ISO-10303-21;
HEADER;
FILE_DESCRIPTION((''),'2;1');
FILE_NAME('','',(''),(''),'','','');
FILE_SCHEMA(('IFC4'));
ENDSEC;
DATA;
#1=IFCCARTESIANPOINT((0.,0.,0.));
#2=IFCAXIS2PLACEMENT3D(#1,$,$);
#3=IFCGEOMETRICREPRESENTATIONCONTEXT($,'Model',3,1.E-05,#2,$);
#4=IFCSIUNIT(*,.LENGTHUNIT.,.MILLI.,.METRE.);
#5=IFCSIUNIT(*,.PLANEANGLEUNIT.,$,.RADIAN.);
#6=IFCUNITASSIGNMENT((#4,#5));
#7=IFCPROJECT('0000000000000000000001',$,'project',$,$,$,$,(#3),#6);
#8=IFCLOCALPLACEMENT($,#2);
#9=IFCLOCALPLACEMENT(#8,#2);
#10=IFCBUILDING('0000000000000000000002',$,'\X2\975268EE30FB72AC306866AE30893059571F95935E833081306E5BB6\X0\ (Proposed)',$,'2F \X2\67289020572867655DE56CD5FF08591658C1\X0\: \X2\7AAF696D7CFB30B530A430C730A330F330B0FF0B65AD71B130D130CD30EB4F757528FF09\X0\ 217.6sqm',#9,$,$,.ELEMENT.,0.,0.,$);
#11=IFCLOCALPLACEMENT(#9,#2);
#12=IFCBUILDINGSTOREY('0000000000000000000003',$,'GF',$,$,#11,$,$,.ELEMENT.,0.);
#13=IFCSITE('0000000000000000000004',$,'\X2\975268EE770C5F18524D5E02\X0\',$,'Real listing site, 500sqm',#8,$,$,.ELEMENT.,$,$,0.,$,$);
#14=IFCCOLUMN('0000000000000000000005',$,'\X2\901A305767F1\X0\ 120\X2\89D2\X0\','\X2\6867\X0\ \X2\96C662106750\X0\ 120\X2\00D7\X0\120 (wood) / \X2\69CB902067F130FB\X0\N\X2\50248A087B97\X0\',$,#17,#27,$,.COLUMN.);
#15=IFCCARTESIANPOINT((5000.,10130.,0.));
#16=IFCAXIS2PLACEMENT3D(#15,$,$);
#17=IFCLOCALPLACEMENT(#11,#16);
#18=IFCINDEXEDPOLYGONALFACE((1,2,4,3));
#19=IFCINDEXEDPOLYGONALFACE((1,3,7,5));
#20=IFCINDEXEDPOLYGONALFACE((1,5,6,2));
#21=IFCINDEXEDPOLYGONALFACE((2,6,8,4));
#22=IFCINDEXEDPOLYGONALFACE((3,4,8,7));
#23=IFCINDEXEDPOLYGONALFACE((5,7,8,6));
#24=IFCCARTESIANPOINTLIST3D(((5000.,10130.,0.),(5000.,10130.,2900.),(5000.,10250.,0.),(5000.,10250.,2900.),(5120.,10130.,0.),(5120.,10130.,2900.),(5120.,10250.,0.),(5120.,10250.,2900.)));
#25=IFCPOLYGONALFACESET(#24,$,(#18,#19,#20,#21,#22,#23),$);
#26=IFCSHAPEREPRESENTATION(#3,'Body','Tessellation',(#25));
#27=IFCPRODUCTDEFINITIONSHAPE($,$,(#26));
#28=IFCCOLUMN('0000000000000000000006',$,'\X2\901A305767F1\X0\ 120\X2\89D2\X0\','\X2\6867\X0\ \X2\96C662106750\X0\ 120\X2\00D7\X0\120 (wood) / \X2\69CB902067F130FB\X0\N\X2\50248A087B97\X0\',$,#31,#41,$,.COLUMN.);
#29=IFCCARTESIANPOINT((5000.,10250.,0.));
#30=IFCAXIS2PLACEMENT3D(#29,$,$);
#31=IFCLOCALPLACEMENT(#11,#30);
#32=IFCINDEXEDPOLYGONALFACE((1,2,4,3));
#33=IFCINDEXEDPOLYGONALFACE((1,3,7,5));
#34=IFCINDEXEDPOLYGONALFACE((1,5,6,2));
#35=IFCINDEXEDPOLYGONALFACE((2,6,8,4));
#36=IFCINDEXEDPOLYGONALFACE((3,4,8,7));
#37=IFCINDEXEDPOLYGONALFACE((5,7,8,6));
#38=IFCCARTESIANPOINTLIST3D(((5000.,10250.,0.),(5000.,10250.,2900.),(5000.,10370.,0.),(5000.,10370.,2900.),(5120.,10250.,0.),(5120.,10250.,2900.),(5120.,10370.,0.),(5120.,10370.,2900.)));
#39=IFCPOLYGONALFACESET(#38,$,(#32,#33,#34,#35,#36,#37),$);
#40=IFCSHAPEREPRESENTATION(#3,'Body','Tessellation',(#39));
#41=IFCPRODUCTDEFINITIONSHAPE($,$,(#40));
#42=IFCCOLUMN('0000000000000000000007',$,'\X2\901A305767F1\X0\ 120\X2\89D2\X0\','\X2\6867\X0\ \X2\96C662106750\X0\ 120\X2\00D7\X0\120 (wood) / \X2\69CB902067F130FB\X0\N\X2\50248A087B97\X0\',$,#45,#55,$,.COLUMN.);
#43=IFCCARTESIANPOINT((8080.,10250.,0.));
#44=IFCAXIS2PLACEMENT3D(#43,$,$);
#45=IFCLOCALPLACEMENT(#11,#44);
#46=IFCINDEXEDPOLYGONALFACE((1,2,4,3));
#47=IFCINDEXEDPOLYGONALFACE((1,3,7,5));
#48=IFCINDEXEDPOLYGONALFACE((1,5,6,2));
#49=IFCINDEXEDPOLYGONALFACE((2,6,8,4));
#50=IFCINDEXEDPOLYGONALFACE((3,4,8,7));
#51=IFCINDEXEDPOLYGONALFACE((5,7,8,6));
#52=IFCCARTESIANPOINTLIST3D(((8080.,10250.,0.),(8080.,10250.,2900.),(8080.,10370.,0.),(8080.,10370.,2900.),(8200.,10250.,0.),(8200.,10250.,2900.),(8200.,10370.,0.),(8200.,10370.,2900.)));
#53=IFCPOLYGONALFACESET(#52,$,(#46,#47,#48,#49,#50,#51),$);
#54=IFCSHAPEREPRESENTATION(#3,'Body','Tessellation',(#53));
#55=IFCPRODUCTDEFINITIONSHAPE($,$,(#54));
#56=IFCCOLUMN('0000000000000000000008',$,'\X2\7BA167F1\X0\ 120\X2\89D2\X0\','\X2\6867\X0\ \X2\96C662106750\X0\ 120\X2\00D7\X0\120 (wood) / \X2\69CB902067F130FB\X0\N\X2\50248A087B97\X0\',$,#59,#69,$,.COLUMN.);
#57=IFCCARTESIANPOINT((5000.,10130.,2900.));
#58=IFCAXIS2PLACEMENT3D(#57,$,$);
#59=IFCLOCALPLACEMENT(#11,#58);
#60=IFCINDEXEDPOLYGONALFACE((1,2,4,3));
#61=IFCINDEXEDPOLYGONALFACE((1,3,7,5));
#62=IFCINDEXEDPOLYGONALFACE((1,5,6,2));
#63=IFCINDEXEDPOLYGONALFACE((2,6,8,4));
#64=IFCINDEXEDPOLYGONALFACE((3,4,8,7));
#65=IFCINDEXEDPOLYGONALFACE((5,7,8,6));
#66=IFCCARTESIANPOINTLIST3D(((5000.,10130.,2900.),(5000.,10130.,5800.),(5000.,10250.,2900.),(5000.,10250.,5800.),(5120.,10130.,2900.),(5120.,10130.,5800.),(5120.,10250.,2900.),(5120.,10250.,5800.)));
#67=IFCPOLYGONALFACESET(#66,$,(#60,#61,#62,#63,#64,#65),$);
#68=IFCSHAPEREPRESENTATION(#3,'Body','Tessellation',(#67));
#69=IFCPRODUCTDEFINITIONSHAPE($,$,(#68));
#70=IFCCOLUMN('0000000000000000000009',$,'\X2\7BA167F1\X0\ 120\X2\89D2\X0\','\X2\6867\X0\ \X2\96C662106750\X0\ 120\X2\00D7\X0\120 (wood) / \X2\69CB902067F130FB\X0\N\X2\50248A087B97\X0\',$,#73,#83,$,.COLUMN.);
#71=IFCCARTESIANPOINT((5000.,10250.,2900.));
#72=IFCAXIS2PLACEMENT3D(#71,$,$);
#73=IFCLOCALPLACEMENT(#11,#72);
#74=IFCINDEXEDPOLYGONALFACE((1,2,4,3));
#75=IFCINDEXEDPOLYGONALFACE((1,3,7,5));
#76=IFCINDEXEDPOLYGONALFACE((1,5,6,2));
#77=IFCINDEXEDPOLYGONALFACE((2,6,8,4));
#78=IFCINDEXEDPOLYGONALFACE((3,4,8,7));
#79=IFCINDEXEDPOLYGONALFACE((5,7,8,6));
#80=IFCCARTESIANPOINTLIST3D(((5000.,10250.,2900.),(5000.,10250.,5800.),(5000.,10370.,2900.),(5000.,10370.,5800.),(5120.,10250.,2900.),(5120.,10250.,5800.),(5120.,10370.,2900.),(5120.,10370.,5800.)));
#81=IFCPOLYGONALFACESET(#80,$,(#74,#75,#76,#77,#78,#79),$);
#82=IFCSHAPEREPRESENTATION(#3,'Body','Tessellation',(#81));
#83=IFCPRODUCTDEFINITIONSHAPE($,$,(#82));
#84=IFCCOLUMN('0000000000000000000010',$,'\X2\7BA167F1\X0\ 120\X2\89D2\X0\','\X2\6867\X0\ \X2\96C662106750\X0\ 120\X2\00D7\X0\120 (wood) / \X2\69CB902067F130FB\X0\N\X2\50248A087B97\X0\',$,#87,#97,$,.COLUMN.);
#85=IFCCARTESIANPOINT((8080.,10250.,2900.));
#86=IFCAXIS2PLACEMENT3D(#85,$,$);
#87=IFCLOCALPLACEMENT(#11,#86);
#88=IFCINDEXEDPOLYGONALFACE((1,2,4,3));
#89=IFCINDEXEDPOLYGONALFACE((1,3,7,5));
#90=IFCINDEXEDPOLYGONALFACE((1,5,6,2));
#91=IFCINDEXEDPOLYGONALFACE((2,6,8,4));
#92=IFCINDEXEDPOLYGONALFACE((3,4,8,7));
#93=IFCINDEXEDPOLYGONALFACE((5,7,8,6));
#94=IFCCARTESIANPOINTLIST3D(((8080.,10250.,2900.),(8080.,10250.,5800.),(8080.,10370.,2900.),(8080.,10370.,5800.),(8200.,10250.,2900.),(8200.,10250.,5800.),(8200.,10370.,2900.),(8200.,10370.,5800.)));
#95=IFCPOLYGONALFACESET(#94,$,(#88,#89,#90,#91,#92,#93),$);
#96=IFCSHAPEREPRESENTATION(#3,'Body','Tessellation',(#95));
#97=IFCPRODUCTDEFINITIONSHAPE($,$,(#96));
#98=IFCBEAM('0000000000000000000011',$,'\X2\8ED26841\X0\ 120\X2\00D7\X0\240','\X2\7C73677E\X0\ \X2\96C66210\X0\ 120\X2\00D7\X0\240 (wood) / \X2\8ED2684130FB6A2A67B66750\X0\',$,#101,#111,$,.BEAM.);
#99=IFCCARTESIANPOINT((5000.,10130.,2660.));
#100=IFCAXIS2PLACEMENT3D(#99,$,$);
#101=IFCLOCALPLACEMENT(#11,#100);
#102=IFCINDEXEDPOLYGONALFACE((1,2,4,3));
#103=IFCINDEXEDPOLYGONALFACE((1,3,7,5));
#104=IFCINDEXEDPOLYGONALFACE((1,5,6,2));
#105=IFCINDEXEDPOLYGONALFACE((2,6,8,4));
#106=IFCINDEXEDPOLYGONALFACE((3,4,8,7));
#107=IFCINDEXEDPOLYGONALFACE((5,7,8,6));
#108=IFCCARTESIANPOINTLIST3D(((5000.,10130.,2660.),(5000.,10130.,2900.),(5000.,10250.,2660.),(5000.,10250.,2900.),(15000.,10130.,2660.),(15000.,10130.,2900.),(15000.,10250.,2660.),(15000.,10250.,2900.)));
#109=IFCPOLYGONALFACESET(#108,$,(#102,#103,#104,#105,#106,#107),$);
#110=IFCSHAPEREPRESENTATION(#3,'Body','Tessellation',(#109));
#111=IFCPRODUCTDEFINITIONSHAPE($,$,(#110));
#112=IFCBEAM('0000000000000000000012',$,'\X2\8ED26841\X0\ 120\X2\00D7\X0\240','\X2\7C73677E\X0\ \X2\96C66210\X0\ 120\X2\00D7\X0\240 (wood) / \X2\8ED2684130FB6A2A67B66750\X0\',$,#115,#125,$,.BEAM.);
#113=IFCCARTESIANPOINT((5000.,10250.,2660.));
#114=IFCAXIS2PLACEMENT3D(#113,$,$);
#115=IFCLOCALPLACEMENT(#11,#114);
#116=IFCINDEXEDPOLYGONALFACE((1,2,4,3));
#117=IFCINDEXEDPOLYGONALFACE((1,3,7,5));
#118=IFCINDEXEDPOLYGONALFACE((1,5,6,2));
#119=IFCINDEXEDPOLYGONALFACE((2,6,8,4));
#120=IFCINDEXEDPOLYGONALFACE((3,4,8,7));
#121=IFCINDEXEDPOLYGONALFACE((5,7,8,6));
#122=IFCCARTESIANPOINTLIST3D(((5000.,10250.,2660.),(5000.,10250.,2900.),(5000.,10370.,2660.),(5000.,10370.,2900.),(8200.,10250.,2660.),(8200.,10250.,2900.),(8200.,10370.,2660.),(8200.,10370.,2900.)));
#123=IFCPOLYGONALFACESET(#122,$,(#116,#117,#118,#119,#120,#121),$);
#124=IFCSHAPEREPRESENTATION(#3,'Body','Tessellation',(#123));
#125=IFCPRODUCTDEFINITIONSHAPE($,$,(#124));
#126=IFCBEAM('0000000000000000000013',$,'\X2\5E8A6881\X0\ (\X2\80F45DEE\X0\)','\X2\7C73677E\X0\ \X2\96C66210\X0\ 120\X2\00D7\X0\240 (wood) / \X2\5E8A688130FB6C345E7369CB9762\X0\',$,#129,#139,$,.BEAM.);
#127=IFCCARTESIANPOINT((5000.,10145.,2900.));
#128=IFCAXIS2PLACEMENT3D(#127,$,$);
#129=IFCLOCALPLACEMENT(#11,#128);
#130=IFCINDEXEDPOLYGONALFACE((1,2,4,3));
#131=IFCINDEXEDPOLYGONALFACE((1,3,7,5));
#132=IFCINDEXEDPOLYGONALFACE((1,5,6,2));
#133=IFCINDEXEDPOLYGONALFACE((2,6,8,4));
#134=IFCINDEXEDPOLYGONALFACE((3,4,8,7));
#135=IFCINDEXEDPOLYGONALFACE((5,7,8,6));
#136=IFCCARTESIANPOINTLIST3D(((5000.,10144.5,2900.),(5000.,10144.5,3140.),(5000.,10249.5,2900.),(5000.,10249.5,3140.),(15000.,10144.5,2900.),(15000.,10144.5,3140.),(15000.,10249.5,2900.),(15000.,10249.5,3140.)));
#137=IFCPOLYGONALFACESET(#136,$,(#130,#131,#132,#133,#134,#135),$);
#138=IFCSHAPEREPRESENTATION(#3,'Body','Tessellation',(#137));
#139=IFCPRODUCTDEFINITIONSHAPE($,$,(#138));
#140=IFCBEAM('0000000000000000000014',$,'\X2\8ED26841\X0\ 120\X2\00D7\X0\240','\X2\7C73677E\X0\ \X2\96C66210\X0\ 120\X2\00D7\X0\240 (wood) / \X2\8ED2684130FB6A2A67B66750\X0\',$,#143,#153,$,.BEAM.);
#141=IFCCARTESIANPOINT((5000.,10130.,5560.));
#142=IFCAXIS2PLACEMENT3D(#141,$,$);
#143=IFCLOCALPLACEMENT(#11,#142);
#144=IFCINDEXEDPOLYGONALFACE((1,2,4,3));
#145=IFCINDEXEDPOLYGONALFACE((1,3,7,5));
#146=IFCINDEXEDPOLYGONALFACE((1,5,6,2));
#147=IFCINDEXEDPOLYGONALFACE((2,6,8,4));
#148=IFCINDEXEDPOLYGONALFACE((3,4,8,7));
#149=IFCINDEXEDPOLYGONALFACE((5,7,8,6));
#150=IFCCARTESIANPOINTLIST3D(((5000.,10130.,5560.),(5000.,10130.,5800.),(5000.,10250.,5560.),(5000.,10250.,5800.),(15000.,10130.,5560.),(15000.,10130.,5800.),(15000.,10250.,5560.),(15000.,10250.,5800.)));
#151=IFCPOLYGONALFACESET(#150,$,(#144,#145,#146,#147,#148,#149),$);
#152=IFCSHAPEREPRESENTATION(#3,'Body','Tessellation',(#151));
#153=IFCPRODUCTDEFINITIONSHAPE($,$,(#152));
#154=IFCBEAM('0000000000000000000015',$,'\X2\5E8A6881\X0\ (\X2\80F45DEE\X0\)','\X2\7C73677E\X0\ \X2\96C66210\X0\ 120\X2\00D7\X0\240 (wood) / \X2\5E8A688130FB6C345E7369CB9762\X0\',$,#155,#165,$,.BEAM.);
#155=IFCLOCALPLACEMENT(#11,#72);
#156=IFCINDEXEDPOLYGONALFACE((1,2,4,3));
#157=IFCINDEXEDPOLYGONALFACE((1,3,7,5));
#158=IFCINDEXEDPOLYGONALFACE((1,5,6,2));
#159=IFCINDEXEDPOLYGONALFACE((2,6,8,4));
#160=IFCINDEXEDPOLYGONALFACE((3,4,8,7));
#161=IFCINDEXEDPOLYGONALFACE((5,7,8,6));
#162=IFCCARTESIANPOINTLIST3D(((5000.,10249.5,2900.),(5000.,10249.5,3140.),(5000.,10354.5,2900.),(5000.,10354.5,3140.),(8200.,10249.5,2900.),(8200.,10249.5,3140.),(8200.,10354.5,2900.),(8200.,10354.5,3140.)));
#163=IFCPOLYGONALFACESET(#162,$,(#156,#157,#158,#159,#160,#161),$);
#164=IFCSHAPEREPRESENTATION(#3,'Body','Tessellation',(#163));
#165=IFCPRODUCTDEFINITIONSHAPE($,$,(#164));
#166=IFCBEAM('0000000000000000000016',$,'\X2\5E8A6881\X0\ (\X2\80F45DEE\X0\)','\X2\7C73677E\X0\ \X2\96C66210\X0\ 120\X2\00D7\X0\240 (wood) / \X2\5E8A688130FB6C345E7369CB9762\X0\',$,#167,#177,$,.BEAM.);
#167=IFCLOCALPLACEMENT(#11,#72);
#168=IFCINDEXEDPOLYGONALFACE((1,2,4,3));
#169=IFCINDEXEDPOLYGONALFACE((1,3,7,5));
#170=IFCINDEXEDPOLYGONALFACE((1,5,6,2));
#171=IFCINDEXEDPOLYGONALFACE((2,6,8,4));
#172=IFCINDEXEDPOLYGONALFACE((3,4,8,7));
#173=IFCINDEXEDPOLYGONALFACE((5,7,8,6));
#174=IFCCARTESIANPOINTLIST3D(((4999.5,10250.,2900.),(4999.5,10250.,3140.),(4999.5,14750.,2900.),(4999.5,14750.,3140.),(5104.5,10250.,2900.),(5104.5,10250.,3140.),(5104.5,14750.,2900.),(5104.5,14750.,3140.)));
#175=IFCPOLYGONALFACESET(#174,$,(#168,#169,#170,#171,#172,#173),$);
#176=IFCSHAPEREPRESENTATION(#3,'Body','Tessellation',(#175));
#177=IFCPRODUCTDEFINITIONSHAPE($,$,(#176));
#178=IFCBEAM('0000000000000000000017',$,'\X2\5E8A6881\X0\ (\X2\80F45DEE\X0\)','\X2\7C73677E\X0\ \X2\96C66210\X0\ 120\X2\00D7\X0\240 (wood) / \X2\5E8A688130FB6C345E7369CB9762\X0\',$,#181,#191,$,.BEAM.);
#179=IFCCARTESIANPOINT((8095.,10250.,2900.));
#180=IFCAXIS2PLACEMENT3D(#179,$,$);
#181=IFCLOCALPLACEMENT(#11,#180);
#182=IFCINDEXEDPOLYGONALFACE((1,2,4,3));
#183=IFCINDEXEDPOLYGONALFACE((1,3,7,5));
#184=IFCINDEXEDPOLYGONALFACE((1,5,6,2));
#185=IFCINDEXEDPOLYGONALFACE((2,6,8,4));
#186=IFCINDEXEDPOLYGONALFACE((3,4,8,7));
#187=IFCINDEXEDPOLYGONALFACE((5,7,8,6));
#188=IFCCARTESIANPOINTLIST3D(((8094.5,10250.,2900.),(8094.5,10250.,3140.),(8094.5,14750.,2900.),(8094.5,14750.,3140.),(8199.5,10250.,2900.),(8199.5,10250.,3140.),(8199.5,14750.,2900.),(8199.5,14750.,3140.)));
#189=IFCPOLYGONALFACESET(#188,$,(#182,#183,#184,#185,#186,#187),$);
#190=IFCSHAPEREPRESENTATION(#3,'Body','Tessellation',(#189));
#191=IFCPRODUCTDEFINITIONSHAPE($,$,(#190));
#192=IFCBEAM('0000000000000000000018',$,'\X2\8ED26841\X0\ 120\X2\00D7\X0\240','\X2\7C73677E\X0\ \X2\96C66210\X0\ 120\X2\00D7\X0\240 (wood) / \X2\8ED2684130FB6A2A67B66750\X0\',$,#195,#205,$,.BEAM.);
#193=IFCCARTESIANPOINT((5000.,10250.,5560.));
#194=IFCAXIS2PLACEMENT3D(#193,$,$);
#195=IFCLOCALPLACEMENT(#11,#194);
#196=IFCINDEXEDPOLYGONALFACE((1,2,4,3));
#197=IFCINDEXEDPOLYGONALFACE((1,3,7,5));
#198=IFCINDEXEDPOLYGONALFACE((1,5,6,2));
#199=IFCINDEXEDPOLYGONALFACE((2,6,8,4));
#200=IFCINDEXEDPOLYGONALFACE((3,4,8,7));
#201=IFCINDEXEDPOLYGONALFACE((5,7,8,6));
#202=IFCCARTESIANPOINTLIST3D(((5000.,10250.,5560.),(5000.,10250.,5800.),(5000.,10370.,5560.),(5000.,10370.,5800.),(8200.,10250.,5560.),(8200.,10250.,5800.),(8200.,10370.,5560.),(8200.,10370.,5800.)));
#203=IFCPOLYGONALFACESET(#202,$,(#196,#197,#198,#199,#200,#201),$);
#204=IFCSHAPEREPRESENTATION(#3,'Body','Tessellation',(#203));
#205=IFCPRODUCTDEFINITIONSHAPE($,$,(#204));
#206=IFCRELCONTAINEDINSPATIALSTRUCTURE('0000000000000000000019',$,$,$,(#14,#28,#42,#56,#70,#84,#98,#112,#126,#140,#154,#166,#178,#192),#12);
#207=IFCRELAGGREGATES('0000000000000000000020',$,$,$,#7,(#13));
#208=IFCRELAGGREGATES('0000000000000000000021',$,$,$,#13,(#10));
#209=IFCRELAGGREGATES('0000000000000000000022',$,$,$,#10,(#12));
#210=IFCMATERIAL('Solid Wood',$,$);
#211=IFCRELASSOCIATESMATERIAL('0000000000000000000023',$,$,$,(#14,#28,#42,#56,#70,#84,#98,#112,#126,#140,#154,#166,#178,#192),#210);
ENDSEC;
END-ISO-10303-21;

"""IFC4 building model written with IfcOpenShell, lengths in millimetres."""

from ifc_helpers import new_model, si_unit, frame, frame_2d, origin, place, context, project, spatial, rectangle, extrude, material, element, save


model = new_model("IFC4")

# Units and contexts
model_context = context("Model", 3, precision=1e-05, world=origin())
ifc_project = project(units=[si_unit("LENGTHUNIT", "METRE", prefix="MILLI"), si_unit("PLANEANGLEUNIT", "RADIAN")], contexts=[model_context])

# Site, building, storey
site_placement = place(None, origin())
site = spatial("IfcSite", under=ifc_project, at=site_placement, Name="青森県弘前市", ObjectType="Real listing site, 500sqm", CompositionType="ELEMENT", RefElevation=0.0)
building_placement = place(site_placement, origin())
building = spatial("IfcBuilding", under=site, at=building_placement, Name="青森・犬と暮らす土間広めの家 (Proposed)", ObjectType="2F 木造在来工法（外壁: 窯業系サイディング＋断熱パネル併用） 217.6sqm", CompositionType="ELEMENT", ElevationOfRefHeight=0.0, ElevationOfTerrain=0.0)
storey_placement = place(building_placement, origin())
storey = spatial("IfcBuildingStorey", under=building, at=storey_placement, Name="GF", CompositionType="ELEMENT", Elevation=0.0)

# Columns
ifc_material_1 = material(Name="Solid Wood")
column_1_placement = place(storey_placement, frame((5000.0, 10130.0, 0.0)))
element("IfcColumn", 1, at=column_1_placement, inside=storey, material=ifc_material_1, Name="通し柱 120角", Description="桧 集成材 120×120 (wood) / 構造柱・N値計算", PredefinedType="COLUMN", context=model_context, shape_type="SweptSolid", body=[
    extrude(rectangle(XDim=120.0, YDim=120.0, at=frame_2d((60.0, 60.0))), frame((5000.0, 10130.0, 0.0)), (0.0, 0.0, 1.0), 2900.0),
])
column_2_placement = place(storey_placement, frame((5000.0, 10250.0, 0.0)))
element("IfcColumn", 2, at=column_2_placement, inside=storey, material=ifc_material_1, Name="通し柱 120角", Description="桧 集成材 120×120 (wood) / 構造柱・N値計算", PredefinedType="COLUMN", context=model_context, shape_type="SweptSolid", body=[
    extrude(rectangle(XDim=120.0, YDim=120.0, at=frame_2d((60.0, 60.0))), frame((5000.0, 10250.0, 0.0)), (0.0, 0.0, 1.0), 2900.0),
])
column_3_placement = place(storey_placement, frame((8080.0, 10250.0, 0.0)))
element("IfcColumn", 3, at=column_3_placement, inside=storey, material=ifc_material_1, Name="通し柱 120角", Description="桧 集成材 120×120 (wood) / 構造柱・N値計算", PredefinedType="COLUMN", context=model_context, shape_type="SweptSolid", body=[
    extrude(rectangle(XDim=120.0, YDim=120.0, at=frame_2d((60.0, 60.0))), frame((8080.0, 10250.0, 0.0)), (0.0, 0.0, 1.0), 2900.0),
])
column_4_placement = place(storey_placement, frame((5000.0, 10130.0, 2900.0)))
element("IfcColumn", 4, at=column_4_placement, inside=storey, material=ifc_material_1, Name="管柱 120角", Description="桧 集成材 120×120 (wood) / 構造柱・N値計算", PredefinedType="COLUMN", context=model_context, shape_type="SweptSolid", body=[
    extrude(rectangle(XDim=120.0, YDim=120.0, at=frame_2d((60.0, 60.0))), frame((5000.0, 10130.0, 2900.0)), (0.0, 0.0, 1.0), 2900.0),
])
column_5_placement = place(storey_placement, frame((5000.0, 10250.0, 2900.0)))
element("IfcColumn", 5, at=column_5_placement, inside=storey, material=ifc_material_1, Name="管柱 120角", Description="桧 集成材 120×120 (wood) / 構造柱・N値計算", PredefinedType="COLUMN", context=model_context, shape_type="SweptSolid", body=[
    extrude(rectangle(XDim=120.0, YDim=120.0, at=frame_2d((60.0, 60.0))), frame((5000.0, 10250.0, 2900.0)), (0.0, 0.0, 1.0), 2900.0),
])
column_6_placement = place(storey_placement, frame((8080.0, 10250.0, 2900.0)))
element("IfcColumn", 6, at=column_6_placement, inside=storey, material=ifc_material_1, Name="管柱 120角", Description="桧 集成材 120×120 (wood) / 構造柱・N値計算", PredefinedType="COLUMN", context=model_context, shape_type="SweptSolid", body=[
    extrude(rectangle(XDim=120.0, YDim=120.0, at=frame_2d((60.0, 60.0))), frame((8080.0, 10250.0, 2900.0)), (0.0, 0.0, 1.0), 2900.0),
])

# Beams
beam_1_placement = place(storey_placement, frame((5000.0, 10130.0, 2660.0)))
element("IfcBeam", 7, at=beam_1_placement, inside=storey, material=ifc_material_1, Name="軒桁 120×240", Description="米松 集成 120×240 (wood) / 軒桁・横架材", PredefinedType="BEAM", context=model_context, shape_type="SweptSolid", body=[
    extrude(rectangle(XDim=10000.0, YDim=120.0, at=frame_2d((5000.0, 60.0))), frame((5000.0, 10130.0, 2660.0)), (0.0, 0.0, 1.0), 240.0),
])
beam_2_placement = place(storey_placement, frame((5000.0, 10250.0, 2660.0)))
element("IfcBeam", 8, at=beam_2_placement, inside=storey, material=ifc_material_1, Name="軒桁 120×240", Description="米松 集成 120×240 (wood) / 軒桁・横架材", PredefinedType="BEAM", context=model_context, shape_type="SweptSolid", body=[
    extrude(rectangle(XDim=3200.0, YDim=120.0, at=frame_2d((1600.0, 60.0))), frame((5000.0, 10250.0, 2660.0)), (0.0, 0.0, 1.0), 240.0),
])
beam_3_placement = place(storey_placement, frame((5000.0, 10145.0, 2900.0)))
element("IfcBeam", 9, at=beam_3_placement, inside=storey, material=ifc_material_1, Name="床梁 (胴差)", Description="米松 集成 120×240 (wood) / 床梁・水平構面", PredefinedType="BEAM", context=model_context, shape_type="SweptSolid", body=[
    extrude(rectangle(XDim=10000.0, YDim=105.0, at=frame_2d((5000.0, 52.0))), frame((5000.0, 10145.0, 2900.0)), (0.0, 0.0, 1.0), 240.0),
])
beam_4_placement = place(storey_placement, frame((5000.0, 10130.0, 5560.0)))
element("IfcBeam", 10, at=beam_4_placement, inside=storey, material=ifc_material_1, Name="軒桁 120×240", Description="米松 集成 120×240 (wood) / 軒桁・横架材", PredefinedType="BEAM", context=model_context, shape_type="SweptSolid", body=[
    extrude(rectangle(XDim=10000.0, YDim=120.0, at=frame_2d((5000.0, 60.0))), frame((5000.0, 10130.0, 5560.0)), (0.0, 0.0, 1.0), 240.0),
])
beam_5_placement = place(storey_placement, frame((5000.0, 10250.0, 2900.0)))
element("IfcBeam", 11, at=beam_5_placement, inside=storey, material=ifc_material_1, Name="床梁 (胴差)", Description="米松 集成 120×240 (wood) / 床梁・水平構面", PredefinedType="BEAM", context=model_context, shape_type="SweptSolid", body=[
    extrude(rectangle(XDim=3200.0, YDim=105.0, at=frame_2d((1600.0, 52.0))), frame((5000.0, 10250.0, 2900.0)), (0.0, 0.0, 1.0), 240.0),
])
beam_6_placement = place(storey_placement, frame((5000.0, 10250.0, 2900.0)))
element("IfcBeam", 12, at=beam_6_placement, inside=storey, material=ifc_material_1, Name="床梁 (胴差)", Description="米松 集成 120×240 (wood) / 床梁・水平構面", PredefinedType="BEAM", context=model_context, shape_type="SweptSolid", body=[
    extrude(rectangle(XDim=105.0, YDim=4500.0, at=frame_2d((52.0, 2250.0))), frame((5000.0, 10250.0, 2900.0)), (0.0, 0.0, 1.0), 240.0),
])
beam_7_placement = place(storey_placement, frame((8095.0, 10250.0, 2900.0)))
element("IfcBeam", 13, at=beam_7_placement, inside=storey, material=ifc_material_1, Name="床梁 (胴差)", Description="米松 集成 120×240 (wood) / 床梁・水平構面", PredefinedType="BEAM", context=model_context, shape_type="SweptSolid", body=[
    extrude(rectangle(XDim=105.0, YDim=4500.0, at=frame_2d((52.0, 2250.0))), frame((8095.0, 10250.0, 2900.0)), (0.0, 0.0, 1.0), 240.0),
])
beam_8_placement = place(storey_placement, frame((5000.0, 10250.0, 5560.0)))
element("IfcBeam", 14, at=beam_8_placement, inside=storey, material=ifc_material_1, Name="軒桁 120×240", Description="米松 集成 120×240 (wood) / 軒桁・横架材", PredefinedType="BEAM", context=model_context, shape_type="SweptSolid", body=[
    extrude(rectangle(XDim=3200.0, YDim=120.0, at=frame_2d((1600.0, 60.0))), frame((5000.0, 10250.0, 5560.0)), (0.0, 0.0, 1.0), 240.0),
])

save(model, "model.ifc")
